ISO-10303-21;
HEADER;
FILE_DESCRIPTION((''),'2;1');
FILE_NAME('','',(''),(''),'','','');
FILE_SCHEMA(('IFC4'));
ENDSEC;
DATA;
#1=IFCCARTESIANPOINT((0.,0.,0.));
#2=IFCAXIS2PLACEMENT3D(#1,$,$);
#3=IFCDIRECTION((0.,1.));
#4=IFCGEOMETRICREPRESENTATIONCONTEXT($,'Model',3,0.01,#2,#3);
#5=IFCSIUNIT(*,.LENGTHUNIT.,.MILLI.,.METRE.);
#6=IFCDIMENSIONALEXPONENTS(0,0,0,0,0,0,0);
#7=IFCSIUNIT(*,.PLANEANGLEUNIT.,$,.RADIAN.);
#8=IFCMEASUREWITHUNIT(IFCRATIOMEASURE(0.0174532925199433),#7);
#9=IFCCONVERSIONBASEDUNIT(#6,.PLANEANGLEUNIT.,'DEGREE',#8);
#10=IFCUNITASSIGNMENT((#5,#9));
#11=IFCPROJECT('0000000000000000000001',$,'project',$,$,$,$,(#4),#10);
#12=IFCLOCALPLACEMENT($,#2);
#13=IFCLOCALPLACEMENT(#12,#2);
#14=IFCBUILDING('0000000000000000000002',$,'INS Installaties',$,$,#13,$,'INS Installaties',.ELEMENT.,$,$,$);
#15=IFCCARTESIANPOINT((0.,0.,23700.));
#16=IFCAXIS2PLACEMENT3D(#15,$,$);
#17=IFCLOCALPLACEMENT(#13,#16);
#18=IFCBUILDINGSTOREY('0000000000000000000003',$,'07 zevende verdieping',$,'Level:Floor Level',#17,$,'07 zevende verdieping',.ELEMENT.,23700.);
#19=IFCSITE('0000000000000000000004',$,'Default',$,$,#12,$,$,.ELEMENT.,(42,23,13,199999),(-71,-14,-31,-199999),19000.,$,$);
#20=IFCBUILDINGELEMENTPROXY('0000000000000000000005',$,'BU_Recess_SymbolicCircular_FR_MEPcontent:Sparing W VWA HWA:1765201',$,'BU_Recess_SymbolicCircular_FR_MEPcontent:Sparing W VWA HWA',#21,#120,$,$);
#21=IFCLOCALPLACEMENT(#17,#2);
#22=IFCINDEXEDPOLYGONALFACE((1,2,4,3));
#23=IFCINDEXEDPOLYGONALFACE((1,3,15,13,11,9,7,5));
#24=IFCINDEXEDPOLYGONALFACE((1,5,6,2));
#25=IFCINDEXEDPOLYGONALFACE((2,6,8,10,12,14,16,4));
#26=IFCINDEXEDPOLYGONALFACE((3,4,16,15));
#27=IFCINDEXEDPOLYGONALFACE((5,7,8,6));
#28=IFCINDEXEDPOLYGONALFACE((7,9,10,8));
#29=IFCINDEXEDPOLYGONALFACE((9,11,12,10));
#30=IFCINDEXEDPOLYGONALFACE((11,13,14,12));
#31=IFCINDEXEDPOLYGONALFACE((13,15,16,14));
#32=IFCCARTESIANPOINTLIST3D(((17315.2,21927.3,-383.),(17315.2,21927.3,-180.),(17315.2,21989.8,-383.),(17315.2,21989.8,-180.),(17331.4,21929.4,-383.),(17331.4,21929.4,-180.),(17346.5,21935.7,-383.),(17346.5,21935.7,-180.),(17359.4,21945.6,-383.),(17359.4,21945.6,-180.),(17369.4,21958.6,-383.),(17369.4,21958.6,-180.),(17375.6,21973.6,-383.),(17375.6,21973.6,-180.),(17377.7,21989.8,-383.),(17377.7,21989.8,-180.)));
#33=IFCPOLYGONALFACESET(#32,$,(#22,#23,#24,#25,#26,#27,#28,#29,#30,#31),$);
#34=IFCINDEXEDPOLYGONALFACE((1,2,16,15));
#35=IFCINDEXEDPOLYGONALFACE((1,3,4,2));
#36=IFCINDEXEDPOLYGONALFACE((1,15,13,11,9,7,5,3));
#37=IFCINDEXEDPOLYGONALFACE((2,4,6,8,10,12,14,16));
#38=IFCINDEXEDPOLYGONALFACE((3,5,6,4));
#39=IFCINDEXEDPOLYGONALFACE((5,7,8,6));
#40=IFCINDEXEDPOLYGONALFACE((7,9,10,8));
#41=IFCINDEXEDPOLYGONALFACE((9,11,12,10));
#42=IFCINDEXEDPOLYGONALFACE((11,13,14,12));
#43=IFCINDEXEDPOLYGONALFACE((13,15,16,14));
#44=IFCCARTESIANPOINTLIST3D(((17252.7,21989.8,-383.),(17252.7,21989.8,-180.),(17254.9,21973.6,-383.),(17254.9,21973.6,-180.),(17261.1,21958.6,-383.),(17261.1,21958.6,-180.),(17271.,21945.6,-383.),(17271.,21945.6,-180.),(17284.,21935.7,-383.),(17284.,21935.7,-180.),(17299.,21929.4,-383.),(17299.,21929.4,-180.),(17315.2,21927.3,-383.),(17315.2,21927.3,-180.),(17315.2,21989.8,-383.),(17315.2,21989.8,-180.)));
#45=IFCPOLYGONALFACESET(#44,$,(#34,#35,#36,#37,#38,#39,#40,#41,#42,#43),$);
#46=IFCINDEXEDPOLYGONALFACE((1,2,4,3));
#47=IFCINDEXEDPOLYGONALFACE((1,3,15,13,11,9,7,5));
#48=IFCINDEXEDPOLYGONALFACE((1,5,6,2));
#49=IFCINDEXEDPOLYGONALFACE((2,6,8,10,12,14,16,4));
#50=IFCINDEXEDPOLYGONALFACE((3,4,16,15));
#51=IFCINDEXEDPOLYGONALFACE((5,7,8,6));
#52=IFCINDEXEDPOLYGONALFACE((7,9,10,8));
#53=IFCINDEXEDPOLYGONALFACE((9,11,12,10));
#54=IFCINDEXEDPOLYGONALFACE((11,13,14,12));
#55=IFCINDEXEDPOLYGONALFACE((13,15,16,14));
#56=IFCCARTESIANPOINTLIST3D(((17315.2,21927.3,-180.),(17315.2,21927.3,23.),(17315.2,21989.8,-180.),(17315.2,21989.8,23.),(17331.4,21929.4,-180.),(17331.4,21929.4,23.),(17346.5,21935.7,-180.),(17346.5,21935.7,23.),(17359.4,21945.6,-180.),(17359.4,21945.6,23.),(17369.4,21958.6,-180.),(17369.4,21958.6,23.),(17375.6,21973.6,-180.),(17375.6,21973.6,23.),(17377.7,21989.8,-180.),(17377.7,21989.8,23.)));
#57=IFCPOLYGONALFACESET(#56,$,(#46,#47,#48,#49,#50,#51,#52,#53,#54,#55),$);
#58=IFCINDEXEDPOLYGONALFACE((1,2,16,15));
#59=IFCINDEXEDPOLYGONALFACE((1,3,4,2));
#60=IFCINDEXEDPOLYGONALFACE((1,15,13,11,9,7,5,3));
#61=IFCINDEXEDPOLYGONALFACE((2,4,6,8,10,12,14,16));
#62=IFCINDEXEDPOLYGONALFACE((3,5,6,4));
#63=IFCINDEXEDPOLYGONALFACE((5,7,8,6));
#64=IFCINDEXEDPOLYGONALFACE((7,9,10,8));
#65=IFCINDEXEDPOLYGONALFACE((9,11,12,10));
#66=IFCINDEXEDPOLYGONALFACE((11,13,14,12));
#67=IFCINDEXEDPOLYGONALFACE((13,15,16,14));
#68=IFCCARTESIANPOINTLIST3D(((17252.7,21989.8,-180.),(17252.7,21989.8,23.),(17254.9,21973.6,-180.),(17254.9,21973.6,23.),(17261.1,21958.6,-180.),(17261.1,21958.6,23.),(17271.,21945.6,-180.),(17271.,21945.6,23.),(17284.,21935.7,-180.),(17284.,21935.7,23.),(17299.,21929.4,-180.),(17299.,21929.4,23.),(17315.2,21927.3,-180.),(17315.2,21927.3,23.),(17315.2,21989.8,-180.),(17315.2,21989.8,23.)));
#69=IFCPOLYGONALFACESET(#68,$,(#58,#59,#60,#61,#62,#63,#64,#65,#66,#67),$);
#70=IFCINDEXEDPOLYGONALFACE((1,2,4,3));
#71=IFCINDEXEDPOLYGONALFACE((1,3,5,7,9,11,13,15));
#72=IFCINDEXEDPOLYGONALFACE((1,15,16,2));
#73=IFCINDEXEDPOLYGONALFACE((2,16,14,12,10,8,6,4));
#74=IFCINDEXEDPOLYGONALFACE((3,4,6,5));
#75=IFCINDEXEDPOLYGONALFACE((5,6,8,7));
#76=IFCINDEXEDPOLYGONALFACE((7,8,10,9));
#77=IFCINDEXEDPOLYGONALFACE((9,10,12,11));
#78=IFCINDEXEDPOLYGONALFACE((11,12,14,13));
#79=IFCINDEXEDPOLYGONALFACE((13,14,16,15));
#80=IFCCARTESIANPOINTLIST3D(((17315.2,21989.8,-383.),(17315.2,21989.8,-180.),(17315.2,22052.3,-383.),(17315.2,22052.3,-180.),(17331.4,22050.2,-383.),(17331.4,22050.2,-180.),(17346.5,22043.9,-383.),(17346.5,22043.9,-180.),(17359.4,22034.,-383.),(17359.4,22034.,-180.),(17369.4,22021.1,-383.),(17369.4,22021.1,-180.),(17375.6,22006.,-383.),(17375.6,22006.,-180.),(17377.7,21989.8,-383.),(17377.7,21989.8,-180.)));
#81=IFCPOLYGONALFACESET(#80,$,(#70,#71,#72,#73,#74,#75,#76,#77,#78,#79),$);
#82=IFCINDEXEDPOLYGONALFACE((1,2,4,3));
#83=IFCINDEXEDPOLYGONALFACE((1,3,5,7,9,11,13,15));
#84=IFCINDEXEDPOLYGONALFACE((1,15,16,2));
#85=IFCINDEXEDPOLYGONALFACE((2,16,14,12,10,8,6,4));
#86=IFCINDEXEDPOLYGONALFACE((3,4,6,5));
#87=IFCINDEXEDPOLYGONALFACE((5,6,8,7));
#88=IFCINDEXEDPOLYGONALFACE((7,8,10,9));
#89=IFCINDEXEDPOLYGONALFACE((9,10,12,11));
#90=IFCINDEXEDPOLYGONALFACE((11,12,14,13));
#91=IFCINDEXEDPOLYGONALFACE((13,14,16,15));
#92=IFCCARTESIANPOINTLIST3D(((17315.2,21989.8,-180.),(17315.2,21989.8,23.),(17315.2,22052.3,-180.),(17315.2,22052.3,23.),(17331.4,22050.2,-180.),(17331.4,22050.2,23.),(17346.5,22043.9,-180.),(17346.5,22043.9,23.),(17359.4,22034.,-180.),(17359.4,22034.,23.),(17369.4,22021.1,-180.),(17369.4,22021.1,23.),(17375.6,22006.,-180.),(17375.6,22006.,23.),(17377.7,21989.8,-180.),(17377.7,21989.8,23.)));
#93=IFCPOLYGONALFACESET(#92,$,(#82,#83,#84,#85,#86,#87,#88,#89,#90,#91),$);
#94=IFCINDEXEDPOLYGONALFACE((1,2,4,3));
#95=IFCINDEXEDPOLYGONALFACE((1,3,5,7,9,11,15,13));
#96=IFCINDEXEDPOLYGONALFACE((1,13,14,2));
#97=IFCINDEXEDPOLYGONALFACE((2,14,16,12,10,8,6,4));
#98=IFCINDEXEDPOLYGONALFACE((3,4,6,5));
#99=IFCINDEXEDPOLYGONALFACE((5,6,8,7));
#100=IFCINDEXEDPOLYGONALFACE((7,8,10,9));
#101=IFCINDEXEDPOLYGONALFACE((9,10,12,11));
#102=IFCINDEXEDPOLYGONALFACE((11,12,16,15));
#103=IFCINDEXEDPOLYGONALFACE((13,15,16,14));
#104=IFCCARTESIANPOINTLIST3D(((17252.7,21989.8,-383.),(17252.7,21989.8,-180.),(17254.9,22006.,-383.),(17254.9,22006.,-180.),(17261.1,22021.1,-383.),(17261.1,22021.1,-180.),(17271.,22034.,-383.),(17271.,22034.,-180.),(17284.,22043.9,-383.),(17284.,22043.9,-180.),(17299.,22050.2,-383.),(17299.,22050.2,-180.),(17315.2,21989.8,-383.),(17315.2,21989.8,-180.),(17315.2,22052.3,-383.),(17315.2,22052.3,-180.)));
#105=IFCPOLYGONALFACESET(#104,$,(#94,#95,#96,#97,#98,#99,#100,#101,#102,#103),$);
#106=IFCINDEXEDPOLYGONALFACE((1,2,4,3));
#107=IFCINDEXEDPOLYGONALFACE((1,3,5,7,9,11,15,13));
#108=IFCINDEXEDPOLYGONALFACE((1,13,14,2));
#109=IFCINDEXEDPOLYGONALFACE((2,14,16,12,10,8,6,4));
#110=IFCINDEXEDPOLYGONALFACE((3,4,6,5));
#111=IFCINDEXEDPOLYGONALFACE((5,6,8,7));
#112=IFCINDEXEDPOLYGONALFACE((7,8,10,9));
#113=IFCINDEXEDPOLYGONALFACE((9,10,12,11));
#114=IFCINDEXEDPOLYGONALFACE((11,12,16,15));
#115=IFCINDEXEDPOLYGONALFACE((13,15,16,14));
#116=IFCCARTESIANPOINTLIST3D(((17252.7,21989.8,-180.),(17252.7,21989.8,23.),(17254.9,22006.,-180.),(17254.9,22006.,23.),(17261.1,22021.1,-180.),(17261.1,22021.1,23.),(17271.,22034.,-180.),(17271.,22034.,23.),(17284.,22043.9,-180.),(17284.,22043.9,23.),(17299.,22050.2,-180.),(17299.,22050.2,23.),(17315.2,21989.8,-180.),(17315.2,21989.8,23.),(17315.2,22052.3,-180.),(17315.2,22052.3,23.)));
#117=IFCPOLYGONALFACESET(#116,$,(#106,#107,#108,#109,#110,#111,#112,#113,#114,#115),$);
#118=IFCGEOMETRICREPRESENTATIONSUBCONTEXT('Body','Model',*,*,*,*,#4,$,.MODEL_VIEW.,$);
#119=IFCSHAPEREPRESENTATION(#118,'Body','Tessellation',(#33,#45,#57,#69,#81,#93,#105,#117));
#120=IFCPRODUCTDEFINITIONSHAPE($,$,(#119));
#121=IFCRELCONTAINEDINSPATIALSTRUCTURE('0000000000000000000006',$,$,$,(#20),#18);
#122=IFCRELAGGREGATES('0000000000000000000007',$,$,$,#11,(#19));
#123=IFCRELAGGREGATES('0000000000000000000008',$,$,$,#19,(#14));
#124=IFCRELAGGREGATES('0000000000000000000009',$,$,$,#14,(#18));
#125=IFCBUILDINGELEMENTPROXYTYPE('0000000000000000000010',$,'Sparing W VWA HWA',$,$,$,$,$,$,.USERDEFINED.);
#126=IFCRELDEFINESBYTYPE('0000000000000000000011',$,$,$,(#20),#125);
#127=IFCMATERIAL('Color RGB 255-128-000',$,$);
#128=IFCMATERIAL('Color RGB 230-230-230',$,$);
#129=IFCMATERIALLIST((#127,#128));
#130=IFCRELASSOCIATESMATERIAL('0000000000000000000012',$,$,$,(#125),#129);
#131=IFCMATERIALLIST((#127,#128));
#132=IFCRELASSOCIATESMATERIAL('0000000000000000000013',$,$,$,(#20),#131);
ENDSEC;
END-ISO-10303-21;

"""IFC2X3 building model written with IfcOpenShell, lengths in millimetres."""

from ifc_helpers import new_model, entity, si_unit, converted_unit, direction, frame, frame_2d, origin, place, context, subcontext, project, spatial, polyline, circle_curve, parameter, trimmed, segment, composite_curve, outline, extrude, source, transform, mapped, material, material_list, type_object, type_shapes, element, save


model = new_model("IFC2X3")

# Units and contexts
model_context = context("Model", 3, precision=0.01, world=origin(), true_north=direction((0.0, 1.0)))
body_context = subcontext(model_context, "Body", "Model", "MODEL_VIEW")
ifc_project = project(units=[si_unit("LENGTHUNIT", "METRE", prefix="MILLI"), converted_unit("PLANEANGLEUNIT", "DEGREE", entity("IfcRatioMeasure", 0.0174532925199433), si_unit("PLANEANGLEUNIT", "RADIAN"), dimensions=[0, 0, 0, 0, 0, 0, 0])], contexts=[model_context])

# Site, building, storey
site_placement = place(None, origin())
site = spatial("IfcSite", under=ifc_project, at=site_placement, Name="Default", CompositionType="ELEMENT", RefLatitude=(42, 23, 13, 199999), RefLongitude=(-71, -14, -31, -199999), RefElevation=19000.0)
building_placement = place(site_placement, origin())
building = spatial("IfcBuilding", under=site, at=building_placement, Name="INS Installaties", LongName="INS Installaties", CompositionType="ELEMENT")
storey_placement = place(building_placement, frame((0.0, 0.0, 23700.0)))
storey = spatial("IfcBuildingStorey", under=building, at=storey_placement, Name="07 zevende verdieping", ObjectType="Level:Floor Level", LongName="07 zevende verdieping", CompositionType="ELEMENT", Elevation=23700.0)

# Building element proxy
ifc_material_1 = material(Name="Color RGB 255-128-000")
ifc_material_2 = material(Name="Color RGB 230-230-230")
ifc_material_list_1 = material_list([ifc_material_1, ifc_material_2])
ifc_material_list_2 = material_list([ifc_material_1, ifc_material_2])
building_element_proxy_type_1 = type_object("IfcBuildingElementProxyType", Name="Sparing W VWA HWA", PredefinedType="USERDEFINED", material=ifc_material_list_2)
shared_shape_1 = source(origin(), body_context, "Body", "SweptSolid", [
    extrude(outline(composite_curve([segment(polyline([(-41.7, -20.8), (20.8, -20.8)]), True, "CONTINUOUS"), segment(polyline([(20.8, -20.8), (20.8, 41.7)]), True, "CONTINUOUS"), segment(trimmed(circle_curve(frame_2d((20.8, -20.8), x_axis=(1.0, 0.0)), 62.5), [parameter(90.0)], [parameter(180.0)], True, "PARAMETER"), True, "CONTINUOUS")], self_intersect=False)), frame((20.8, -20.8, -403.0), z_axis=(0.0, 0.0, 1.0), x_axis=(-1.0, 0.0, 0.0)), (0.0, 0.0, 1.0), 203.0),
    extrude(outline(composite_curve([segment(trimmed(circle_curve(frame_2d((20.8, 20.8), x_axis=(1.0, 0.0)), 62.5), [parameter(180.0)], [parameter(270.0)], True, "PARAMETER"), True, "CONTINUOUS"), segment(polyline([(20.8, -41.7), (20.8, 20.8)]), True, "CONTINUOUS"), segment(polyline([(20.8, 20.8), (-41.7, 20.8)]), True, "CONTINUOUS")], self_intersect=False)), frame((-20.8, -20.8, -403.0)), (0.0, 0.0, 1.0), 203.0),
    extrude(outline(composite_curve([segment(polyline([(-41.7, -20.8), (20.8, -20.8)]), True, "CONTINUOUS"), segment(polyline([(20.8, -20.8), (20.8, 41.7)]), True, "CONTINUOUS"), segment(trimmed(circle_curve(frame_2d((20.8, -20.8), x_axis=(1.0, 0.0)), 62.5), [parameter(90.0)], [parameter(180.0)], True, "PARAMETER"), True, "CONTINUOUS")], self_intersect=False)), frame((20.8, -20.8, -200.0), z_axis=(0.0, 0.0, 1.0), x_axis=(-1.0, 0.0, 0.0)), (0.0, 0.0, 1.0), 203.0),
    extrude(outline(composite_curve([segment(trimmed(circle_curve(frame_2d((20.8, 20.8), x_axis=(1.0, 0.0)), 62.5), [parameter(180.0)], [parameter(270.0)], True, "PARAMETER"), True, "CONTINUOUS"), segment(polyline([(20.8, -41.7), (20.8, 20.8)]), True, "CONTINUOUS"), segment(polyline([(20.8, 20.8), (-41.7, 20.8)]), True, "CONTINUOUS")], self_intersect=False)), frame((-20.8, -20.8, -200.0)), (0.0, 0.0, 1.0), 203.0),
    extrude(outline(composite_curve([segment(trimmed(circle_curve(frame_2d((20.8, 20.8), x_axis=(1.0, 0.0)), 62.5), [parameter(180.0)], [parameter(270.0)], True, "PARAMETER"), True, "CONTINUOUS"), segment(polyline([(20.8, -41.7), (20.8, 20.8)]), True, "CONTINUOUS"), segment(polyline([(20.8, 20.8), (-41.7, 20.8)]), True, "CONTINUOUS")], self_intersect=False)), frame((20.8, 20.8, -403.0), z_axis=(0.0, 0.0, 1.0), x_axis=(-1.0, 0.0, 0.0)), (0.0, 0.0, 1.0), 203.0),
    extrude(outline(composite_curve([segment(trimmed(circle_curve(frame_2d((20.8, 20.8), x_axis=(1.0, 0.0)), 62.5), [parameter(180.0)], [parameter(270.0)], True, "PARAMETER"), True, "CONTINUOUS"), segment(polyline([(20.8, -41.7), (20.8, 20.8)]), True, "CONTINUOUS"), segment(polyline([(20.8, 20.8), (-41.7, 20.8)]), True, "CONTINUOUS")], self_intersect=False)), frame((20.8, 20.8, -200.0), z_axis=(0.0, 0.0, 1.0), x_axis=(-1.0, 0.0, 0.0)), (0.0, 0.0, 1.0), 203.0),
    extrude(outline(composite_curve([segment(polyline([(-41.7, -20.8), (20.8, -20.8)]), True, "CONTINUOUS"), segment(polyline([(20.8, -20.8), (20.8, 41.7)]), True, "CONTINUOUS"), segment(trimmed(circle_curve(frame_2d((20.8, -20.8), x_axis=(1.0, 0.0)), 62.5), [parameter(90.0)], [parameter(180.0)], True, "PARAMETER"), True, "CONTINUOUS")], self_intersect=False)), frame((-20.8, 20.8, -403.0)), (0.0, 0.0, 1.0), 203.0),
    extrude(outline(composite_curve([segment(polyline([(-41.7, -20.8), (20.8, -20.8)]), True, "CONTINUOUS"), segment(polyline([(20.8, -20.8), (20.8, 41.7)]), True, "CONTINUOUS"), segment(trimmed(circle_curve(frame_2d((20.8, -20.8), x_axis=(1.0, 0.0)), 62.5), [parameter(90.0)], [parameter(180.0)], True, "PARAMETER"), True, "CONTINUOUS")], self_intersect=False)), frame((-20.8, 20.8, -200.0)), (0.0, 0.0, 1.0), 203.0),
])
type_shapes(building_element_proxy_type_1, [shared_shape_1])
proxy_1_placement = place(storey_placement, frame((17315.2, 21989.8, 20.0)))
element("IfcBuildingElementProxy", 1, at=proxy_1_placement, inside=storey, type_object=building_element_proxy_type_1, material=ifc_material_list_1, Name="BU_Recess_SymbolicCircular_FR_MEPcontent:Sparing W VWA HWA:1765201", ObjectType="BU_Recess_SymbolicCircular_FR_MEPcontent:Sparing W VWA HWA", context=body_context, shape_type="MappedRepresentation", body=[
    mapped(shared_shape_1, transform((0.0, 0.0, 0.0), scale=1.0)),
])

save(model, "model.ifc")
